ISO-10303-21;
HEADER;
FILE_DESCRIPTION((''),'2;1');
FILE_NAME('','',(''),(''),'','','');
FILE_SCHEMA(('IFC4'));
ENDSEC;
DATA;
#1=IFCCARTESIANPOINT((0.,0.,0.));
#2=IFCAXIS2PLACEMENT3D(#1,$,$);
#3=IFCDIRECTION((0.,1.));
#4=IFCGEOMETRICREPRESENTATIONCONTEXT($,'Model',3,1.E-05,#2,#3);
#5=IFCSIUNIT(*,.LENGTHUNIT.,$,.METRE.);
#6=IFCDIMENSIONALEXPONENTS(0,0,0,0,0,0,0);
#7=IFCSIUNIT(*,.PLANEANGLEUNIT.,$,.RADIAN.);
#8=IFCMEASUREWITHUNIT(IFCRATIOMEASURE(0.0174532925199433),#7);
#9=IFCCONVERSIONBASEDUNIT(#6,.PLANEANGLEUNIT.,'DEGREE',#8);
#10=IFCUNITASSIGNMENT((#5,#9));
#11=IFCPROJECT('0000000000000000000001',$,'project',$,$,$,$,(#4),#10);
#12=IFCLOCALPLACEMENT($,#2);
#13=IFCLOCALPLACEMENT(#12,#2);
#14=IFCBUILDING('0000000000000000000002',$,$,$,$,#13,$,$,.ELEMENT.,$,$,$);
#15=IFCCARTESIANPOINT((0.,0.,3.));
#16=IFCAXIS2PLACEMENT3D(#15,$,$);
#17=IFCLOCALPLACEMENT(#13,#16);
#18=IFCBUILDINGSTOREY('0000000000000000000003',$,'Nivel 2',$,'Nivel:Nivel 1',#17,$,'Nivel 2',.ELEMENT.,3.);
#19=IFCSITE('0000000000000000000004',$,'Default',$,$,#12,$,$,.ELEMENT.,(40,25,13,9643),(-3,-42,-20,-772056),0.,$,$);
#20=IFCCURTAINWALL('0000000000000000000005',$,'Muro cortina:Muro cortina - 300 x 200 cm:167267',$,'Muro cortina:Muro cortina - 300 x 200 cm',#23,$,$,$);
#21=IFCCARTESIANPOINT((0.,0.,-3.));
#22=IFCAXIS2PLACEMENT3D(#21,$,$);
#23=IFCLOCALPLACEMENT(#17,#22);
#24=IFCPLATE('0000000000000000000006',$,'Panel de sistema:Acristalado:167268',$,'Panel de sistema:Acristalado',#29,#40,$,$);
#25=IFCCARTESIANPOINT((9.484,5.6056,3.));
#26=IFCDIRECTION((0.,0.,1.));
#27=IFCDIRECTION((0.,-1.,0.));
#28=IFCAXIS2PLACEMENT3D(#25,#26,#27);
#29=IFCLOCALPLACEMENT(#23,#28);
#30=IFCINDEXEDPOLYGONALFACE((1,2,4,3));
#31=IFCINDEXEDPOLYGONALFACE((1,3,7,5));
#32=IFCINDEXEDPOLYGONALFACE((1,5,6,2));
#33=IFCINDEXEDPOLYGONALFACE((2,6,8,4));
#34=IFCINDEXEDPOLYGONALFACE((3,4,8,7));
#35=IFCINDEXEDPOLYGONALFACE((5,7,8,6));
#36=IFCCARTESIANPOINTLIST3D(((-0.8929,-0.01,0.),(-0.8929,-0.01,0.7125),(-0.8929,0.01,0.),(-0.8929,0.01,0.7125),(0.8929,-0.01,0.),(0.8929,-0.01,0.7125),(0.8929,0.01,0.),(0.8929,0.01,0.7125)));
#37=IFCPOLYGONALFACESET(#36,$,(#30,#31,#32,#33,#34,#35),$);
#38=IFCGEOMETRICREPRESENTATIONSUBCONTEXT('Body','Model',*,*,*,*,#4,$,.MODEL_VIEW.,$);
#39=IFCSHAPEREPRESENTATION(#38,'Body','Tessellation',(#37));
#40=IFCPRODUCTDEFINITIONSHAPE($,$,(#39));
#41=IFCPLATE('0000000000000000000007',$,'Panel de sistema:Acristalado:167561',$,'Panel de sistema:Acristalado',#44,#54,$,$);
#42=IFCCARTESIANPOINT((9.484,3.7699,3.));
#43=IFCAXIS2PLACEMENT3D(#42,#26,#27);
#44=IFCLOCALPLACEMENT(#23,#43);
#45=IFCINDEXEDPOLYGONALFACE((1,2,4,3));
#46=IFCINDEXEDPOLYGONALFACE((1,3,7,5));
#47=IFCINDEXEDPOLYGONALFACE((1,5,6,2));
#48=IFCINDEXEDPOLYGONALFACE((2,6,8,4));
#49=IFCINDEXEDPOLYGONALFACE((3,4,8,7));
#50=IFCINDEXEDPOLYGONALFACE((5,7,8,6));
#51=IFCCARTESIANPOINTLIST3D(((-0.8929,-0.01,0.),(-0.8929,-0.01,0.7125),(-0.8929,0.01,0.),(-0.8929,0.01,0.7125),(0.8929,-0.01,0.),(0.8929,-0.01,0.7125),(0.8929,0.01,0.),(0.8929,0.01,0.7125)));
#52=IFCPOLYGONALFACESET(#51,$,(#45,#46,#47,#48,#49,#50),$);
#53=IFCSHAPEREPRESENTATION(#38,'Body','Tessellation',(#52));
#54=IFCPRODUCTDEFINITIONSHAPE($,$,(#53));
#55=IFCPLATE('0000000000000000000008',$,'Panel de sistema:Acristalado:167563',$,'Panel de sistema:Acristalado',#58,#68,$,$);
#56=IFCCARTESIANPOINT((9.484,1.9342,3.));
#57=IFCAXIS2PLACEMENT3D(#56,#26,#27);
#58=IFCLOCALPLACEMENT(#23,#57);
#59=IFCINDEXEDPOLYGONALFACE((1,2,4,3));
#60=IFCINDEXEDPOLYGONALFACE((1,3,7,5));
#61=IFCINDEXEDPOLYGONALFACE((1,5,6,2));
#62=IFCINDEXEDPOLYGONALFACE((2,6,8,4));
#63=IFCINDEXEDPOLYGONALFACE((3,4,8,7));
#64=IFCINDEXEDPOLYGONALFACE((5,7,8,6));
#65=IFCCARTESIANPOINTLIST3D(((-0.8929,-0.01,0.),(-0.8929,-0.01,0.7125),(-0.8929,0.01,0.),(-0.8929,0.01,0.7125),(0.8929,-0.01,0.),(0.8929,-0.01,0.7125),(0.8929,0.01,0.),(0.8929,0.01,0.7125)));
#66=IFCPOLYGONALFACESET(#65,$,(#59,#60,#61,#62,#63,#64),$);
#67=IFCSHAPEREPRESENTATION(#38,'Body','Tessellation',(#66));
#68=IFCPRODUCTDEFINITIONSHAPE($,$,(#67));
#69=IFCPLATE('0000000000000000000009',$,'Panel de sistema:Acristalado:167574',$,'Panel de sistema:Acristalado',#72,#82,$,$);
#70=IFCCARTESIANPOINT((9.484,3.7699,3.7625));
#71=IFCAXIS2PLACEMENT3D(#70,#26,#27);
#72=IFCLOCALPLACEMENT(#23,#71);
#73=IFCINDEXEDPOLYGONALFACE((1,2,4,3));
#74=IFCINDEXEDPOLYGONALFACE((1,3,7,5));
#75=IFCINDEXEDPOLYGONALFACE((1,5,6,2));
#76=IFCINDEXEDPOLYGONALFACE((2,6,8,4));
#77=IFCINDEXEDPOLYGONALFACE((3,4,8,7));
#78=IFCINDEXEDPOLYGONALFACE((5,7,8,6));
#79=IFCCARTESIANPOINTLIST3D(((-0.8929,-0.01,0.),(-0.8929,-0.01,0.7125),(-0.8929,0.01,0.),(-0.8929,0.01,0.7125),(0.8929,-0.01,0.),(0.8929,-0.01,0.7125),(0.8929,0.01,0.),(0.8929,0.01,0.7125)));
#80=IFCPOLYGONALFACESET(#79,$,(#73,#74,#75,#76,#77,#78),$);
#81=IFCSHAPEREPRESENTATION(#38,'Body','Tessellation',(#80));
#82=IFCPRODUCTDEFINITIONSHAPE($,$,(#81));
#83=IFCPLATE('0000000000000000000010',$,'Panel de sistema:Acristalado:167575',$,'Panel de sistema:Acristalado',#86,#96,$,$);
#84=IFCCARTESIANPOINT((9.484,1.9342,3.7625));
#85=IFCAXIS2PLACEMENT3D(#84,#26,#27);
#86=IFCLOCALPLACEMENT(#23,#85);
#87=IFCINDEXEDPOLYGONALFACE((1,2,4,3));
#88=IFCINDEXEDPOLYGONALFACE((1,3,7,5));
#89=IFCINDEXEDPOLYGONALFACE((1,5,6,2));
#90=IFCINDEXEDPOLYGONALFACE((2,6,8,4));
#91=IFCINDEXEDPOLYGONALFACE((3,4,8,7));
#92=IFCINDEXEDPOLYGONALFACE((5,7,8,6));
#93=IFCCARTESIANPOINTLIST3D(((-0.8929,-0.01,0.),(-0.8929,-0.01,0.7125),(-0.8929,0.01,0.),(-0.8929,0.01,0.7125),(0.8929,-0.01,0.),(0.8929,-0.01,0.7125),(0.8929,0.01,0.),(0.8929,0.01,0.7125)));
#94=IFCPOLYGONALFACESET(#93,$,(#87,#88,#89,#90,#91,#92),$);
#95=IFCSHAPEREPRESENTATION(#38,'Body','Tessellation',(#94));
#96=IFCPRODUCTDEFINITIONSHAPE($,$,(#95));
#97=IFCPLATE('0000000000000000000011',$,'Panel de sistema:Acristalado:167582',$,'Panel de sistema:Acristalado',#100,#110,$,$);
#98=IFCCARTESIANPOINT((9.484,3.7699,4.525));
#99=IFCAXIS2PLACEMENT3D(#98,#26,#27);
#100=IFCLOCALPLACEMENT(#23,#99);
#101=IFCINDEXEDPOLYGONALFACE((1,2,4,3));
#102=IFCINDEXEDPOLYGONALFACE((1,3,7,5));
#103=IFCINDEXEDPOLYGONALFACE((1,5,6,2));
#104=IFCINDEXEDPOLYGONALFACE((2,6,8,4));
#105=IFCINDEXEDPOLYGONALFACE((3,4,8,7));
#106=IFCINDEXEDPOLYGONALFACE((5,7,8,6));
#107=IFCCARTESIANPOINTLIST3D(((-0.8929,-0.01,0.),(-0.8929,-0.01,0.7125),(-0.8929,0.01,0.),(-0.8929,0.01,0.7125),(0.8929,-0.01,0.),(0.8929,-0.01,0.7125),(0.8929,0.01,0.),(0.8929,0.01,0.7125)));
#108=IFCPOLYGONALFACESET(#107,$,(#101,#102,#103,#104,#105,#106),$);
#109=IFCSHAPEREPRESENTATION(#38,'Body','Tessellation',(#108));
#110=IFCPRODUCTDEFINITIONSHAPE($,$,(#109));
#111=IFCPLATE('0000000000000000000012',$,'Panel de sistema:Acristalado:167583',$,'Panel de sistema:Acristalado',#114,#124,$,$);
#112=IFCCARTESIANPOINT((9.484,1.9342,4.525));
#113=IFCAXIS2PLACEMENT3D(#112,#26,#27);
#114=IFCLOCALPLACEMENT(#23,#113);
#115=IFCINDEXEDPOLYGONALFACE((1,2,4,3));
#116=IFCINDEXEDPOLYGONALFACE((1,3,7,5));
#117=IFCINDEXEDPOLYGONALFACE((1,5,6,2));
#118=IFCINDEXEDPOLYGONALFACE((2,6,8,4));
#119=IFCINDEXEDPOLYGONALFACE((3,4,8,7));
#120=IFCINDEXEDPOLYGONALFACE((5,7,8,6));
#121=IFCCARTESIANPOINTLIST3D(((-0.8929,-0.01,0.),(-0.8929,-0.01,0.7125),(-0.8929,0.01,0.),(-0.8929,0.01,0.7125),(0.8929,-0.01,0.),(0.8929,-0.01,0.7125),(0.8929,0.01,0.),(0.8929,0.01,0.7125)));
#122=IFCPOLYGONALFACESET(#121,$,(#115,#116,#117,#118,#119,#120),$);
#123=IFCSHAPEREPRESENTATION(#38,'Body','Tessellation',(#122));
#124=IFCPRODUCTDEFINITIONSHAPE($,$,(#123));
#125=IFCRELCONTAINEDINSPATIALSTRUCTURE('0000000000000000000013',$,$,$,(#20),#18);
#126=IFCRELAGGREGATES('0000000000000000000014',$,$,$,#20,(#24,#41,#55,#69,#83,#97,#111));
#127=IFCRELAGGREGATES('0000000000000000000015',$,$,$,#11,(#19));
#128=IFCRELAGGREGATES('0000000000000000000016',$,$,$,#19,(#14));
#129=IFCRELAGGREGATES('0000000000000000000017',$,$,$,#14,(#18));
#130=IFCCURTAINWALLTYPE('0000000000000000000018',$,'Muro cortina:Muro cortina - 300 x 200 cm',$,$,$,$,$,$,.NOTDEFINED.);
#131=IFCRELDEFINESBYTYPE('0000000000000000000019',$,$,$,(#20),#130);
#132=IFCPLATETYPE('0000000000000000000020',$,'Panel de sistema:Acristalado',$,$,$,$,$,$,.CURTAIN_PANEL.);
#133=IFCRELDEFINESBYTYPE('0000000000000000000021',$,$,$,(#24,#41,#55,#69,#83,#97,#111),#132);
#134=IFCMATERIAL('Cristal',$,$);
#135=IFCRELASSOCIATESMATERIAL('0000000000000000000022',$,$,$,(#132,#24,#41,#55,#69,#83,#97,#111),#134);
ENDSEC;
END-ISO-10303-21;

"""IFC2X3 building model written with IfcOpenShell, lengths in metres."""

from ifc_helpers import new_model, entity, si_unit, converted_unit, direction, frame, origin, origin_2d_with_axis, place, context, subcontext, project, spatial, rectangle, extrude, source, transform, mapped, material, type_object, type_shapes, element, aggregate, save


model = new_model("IFC2X3")

# Units and contexts
model_context = context("Model", 3, precision=1e-05, world=origin(), true_north=direction((0.0, 1.0)))
body_context = subcontext(model_context, "Body", "Model", "MODEL_VIEW")
ifc_project = project(units=[si_unit("LENGTHUNIT", "METRE"), converted_unit("PLANEANGLEUNIT", "DEGREE", entity("IfcRatioMeasure", 0.0174532925199433), si_unit("PLANEANGLEUNIT", "RADIAN"), dimensions=[0, 0, 0, 0, 0, 0, 0])], contexts=[model_context])

# Site, building, storey
site_placement = place(None, origin())
site = spatial("IfcSite", under=ifc_project, at=site_placement, Name="Default", CompositionType="ELEMENT", RefLatitude=(40, 25, 13, 9643), RefLongitude=(-3, -42, -20, -772056), RefElevation=0.0)
building_placement = place(site_placement, origin())
building = spatial("IfcBuilding", under=site, at=building_placement, CompositionType="ELEMENT")
storey_placement = place(building_placement, frame((0.0, 0.0, 3.0)))
storey = spatial("IfcBuildingStorey", under=building, at=storey_placement, Name="Nivel 2", ObjectType="Nivel:Nivel 1", LongName="Nivel 2", CompositionType="ELEMENT", Elevation=3.0)

# Curtain wall, plates
curtain_wall_type = type_object("IfcCurtainWallType", Name="Muro cortina:Muro cortina - 300 x 200 cm", PredefinedType="NOTDEFINED")
curtain_wall_placement = place(storey_placement, frame((0.0, 0.0, -3.0)))
curtain_wall = element("IfcCurtainWall", 1, at=curtain_wall_placement, inside=storey, type_object=curtain_wall_type, Name="Muro cortina:Muro cortina - 300 x 200 cm:167267", ObjectType="Muro cortina:Muro cortina - 300 x 200 cm")
ifc_material_1 = material(Name="Cristal")
plate_type = type_object("IfcPlateType", Name="Panel de sistema:Acristalado", PredefinedType="CURTAIN_PANEL", material=ifc_material_1)
shared_shape_1 = source(origin(), body_context, "Body", "SweptSolid", [
    extrude(rectangle(XDim=0.02, YDim=1.7857, at=origin_2d_with_axis()), frame((0.0, 0.0, 0.0), z_axis=(0.0, 0.0, 1.0), x_axis=(0.0, 1.0, 0.0)), (0.0, 0.0, 1.0), 0.7125),
])
type_shapes(plate_type, [shared_shape_1])
plate_1_placement = place(curtain_wall_placement, frame((9.484, 5.6056, 3.0), z_axis=(0.0, 0.0, 1.0), x_axis=(0.0, -1.0, 0.0)))
plate_1 = element("IfcPlate", 2, at=plate_1_placement, type_object=plate_type, material=ifc_material_1, Name="Panel de sistema:Acristalado:167268", ObjectType="Panel de sistema:Acristalado", context=body_context, shape_type="MappedRepresentation", body=[
    mapped(shared_shape_1, transform((0.0, 0.0, 0.0), scale=1.0)),
])
plate_2_placement = place(curtain_wall_placement, frame((9.484, 3.7699, 3.0), z_axis=(0.0, 0.0, 1.0), x_axis=(0.0, -1.0, 0.0)))
plate_2 = element("IfcPlate", 3, at=plate_2_placement, type_object=plate_type, material=ifc_material_1, Name="Panel de sistema:Acristalado:167561", ObjectType="Panel de sistema:Acristalado", context=body_context, shape_type="MappedRepresentation", body=[
    mapped(shared_shape_1, transform((0.0, 0.0, 0.0), scale=1.0)),
])
plate_3_placement = place(curtain_wall_placement, frame((9.484, 1.9342, 3.0), z_axis=(0.0, 0.0, 1.0), x_axis=(0.0, -1.0, 0.0)))
plate_3 = element("IfcPlate", 4, at=plate_3_placement, type_object=plate_type, material=ifc_material_1, Name="Panel de sistema:Acristalado:167563", ObjectType="Panel de sistema:Acristalado", context=body_context, shape_type="MappedRepresentation", body=[
    mapped(shared_shape_1, transform((0.0, 0.0, 0.0), scale=1.0)),
])
plate_4_placement = place(curtain_wall_placement, frame((9.484, 3.7699, 3.7625), z_axis=(0.0, 0.0, 1.0), x_axis=(0.0, -1.0, 0.0)))
plate_4 = element("IfcPlate", 5, at=plate_4_placement, type_object=plate_type, material=ifc_material_1, Name="Panel de sistema:Acristalado:167574", ObjectType="Panel de sistema:Acristalado", context=body_context, shape_type="MappedRepresentation", body=[
    mapped(shared_shape_1, transform((0.0, 0.0, 0.0), scale=1.0)),
])
plate_5_placement = place(curtain_wall_placement, frame((9.484, 1.9342, 3.7625), z_axis=(0.0, 0.0, 1.0), x_axis=(0.0, -1.0, 0.0)))
plate_5 = element("IfcPlate", 6, at=plate_5_placement, type_object=plate_type, material=ifc_material_1, Name="Panel de sistema:Acristalado:167575", ObjectType="Panel de sistema:Acristalado", context=body_context, shape_type="MappedRepresentation", body=[
    mapped(shared_shape_1, transform((0.0, 0.0, 0.0), scale=1.0)),
])
plate_6_placement = place(curtain_wall_placement, frame((9.484, 3.7699, 4.525), z_axis=(0.0, 0.0, 1.0), x_axis=(0.0, -1.0, 0.0)))
plate_6 = element("IfcPlate", 7, at=plate_6_placement, type_object=plate_type, material=ifc_material_1, Name="Panel de sistema:Acristalado:167582", ObjectType="Panel de sistema:Acristalado", context=body_context, shape_type="MappedRepresentation", body=[
    mapped(shared_shape_1, transform((0.0, 0.0, 0.0), scale=1.0)),
])
plate_7_placement = place(curtain_wall_placement, frame((9.484, 1.9342, 4.525), z_axis=(0.0, 0.0, 1.0), x_axis=(0.0, -1.0, 0.0)))
plate_7 = element("IfcPlate", 8, at=plate_7_placement, type_object=plate_type, material=ifc_material_1, Name="Panel de sistema:Acristalado:167583", ObjectType="Panel de sistema:Acristalado", context=body_context, shape_type="MappedRepresentation", body=[
    mapped(shared_shape_1, transform((0.0, 0.0, 0.0), scale=1.0)),
])
aggregate(curtain_wall, [plate_1, plate_2, plate_3, plate_4, plate_5, plate_6, plate_7])

save(model, "model.ifc")
